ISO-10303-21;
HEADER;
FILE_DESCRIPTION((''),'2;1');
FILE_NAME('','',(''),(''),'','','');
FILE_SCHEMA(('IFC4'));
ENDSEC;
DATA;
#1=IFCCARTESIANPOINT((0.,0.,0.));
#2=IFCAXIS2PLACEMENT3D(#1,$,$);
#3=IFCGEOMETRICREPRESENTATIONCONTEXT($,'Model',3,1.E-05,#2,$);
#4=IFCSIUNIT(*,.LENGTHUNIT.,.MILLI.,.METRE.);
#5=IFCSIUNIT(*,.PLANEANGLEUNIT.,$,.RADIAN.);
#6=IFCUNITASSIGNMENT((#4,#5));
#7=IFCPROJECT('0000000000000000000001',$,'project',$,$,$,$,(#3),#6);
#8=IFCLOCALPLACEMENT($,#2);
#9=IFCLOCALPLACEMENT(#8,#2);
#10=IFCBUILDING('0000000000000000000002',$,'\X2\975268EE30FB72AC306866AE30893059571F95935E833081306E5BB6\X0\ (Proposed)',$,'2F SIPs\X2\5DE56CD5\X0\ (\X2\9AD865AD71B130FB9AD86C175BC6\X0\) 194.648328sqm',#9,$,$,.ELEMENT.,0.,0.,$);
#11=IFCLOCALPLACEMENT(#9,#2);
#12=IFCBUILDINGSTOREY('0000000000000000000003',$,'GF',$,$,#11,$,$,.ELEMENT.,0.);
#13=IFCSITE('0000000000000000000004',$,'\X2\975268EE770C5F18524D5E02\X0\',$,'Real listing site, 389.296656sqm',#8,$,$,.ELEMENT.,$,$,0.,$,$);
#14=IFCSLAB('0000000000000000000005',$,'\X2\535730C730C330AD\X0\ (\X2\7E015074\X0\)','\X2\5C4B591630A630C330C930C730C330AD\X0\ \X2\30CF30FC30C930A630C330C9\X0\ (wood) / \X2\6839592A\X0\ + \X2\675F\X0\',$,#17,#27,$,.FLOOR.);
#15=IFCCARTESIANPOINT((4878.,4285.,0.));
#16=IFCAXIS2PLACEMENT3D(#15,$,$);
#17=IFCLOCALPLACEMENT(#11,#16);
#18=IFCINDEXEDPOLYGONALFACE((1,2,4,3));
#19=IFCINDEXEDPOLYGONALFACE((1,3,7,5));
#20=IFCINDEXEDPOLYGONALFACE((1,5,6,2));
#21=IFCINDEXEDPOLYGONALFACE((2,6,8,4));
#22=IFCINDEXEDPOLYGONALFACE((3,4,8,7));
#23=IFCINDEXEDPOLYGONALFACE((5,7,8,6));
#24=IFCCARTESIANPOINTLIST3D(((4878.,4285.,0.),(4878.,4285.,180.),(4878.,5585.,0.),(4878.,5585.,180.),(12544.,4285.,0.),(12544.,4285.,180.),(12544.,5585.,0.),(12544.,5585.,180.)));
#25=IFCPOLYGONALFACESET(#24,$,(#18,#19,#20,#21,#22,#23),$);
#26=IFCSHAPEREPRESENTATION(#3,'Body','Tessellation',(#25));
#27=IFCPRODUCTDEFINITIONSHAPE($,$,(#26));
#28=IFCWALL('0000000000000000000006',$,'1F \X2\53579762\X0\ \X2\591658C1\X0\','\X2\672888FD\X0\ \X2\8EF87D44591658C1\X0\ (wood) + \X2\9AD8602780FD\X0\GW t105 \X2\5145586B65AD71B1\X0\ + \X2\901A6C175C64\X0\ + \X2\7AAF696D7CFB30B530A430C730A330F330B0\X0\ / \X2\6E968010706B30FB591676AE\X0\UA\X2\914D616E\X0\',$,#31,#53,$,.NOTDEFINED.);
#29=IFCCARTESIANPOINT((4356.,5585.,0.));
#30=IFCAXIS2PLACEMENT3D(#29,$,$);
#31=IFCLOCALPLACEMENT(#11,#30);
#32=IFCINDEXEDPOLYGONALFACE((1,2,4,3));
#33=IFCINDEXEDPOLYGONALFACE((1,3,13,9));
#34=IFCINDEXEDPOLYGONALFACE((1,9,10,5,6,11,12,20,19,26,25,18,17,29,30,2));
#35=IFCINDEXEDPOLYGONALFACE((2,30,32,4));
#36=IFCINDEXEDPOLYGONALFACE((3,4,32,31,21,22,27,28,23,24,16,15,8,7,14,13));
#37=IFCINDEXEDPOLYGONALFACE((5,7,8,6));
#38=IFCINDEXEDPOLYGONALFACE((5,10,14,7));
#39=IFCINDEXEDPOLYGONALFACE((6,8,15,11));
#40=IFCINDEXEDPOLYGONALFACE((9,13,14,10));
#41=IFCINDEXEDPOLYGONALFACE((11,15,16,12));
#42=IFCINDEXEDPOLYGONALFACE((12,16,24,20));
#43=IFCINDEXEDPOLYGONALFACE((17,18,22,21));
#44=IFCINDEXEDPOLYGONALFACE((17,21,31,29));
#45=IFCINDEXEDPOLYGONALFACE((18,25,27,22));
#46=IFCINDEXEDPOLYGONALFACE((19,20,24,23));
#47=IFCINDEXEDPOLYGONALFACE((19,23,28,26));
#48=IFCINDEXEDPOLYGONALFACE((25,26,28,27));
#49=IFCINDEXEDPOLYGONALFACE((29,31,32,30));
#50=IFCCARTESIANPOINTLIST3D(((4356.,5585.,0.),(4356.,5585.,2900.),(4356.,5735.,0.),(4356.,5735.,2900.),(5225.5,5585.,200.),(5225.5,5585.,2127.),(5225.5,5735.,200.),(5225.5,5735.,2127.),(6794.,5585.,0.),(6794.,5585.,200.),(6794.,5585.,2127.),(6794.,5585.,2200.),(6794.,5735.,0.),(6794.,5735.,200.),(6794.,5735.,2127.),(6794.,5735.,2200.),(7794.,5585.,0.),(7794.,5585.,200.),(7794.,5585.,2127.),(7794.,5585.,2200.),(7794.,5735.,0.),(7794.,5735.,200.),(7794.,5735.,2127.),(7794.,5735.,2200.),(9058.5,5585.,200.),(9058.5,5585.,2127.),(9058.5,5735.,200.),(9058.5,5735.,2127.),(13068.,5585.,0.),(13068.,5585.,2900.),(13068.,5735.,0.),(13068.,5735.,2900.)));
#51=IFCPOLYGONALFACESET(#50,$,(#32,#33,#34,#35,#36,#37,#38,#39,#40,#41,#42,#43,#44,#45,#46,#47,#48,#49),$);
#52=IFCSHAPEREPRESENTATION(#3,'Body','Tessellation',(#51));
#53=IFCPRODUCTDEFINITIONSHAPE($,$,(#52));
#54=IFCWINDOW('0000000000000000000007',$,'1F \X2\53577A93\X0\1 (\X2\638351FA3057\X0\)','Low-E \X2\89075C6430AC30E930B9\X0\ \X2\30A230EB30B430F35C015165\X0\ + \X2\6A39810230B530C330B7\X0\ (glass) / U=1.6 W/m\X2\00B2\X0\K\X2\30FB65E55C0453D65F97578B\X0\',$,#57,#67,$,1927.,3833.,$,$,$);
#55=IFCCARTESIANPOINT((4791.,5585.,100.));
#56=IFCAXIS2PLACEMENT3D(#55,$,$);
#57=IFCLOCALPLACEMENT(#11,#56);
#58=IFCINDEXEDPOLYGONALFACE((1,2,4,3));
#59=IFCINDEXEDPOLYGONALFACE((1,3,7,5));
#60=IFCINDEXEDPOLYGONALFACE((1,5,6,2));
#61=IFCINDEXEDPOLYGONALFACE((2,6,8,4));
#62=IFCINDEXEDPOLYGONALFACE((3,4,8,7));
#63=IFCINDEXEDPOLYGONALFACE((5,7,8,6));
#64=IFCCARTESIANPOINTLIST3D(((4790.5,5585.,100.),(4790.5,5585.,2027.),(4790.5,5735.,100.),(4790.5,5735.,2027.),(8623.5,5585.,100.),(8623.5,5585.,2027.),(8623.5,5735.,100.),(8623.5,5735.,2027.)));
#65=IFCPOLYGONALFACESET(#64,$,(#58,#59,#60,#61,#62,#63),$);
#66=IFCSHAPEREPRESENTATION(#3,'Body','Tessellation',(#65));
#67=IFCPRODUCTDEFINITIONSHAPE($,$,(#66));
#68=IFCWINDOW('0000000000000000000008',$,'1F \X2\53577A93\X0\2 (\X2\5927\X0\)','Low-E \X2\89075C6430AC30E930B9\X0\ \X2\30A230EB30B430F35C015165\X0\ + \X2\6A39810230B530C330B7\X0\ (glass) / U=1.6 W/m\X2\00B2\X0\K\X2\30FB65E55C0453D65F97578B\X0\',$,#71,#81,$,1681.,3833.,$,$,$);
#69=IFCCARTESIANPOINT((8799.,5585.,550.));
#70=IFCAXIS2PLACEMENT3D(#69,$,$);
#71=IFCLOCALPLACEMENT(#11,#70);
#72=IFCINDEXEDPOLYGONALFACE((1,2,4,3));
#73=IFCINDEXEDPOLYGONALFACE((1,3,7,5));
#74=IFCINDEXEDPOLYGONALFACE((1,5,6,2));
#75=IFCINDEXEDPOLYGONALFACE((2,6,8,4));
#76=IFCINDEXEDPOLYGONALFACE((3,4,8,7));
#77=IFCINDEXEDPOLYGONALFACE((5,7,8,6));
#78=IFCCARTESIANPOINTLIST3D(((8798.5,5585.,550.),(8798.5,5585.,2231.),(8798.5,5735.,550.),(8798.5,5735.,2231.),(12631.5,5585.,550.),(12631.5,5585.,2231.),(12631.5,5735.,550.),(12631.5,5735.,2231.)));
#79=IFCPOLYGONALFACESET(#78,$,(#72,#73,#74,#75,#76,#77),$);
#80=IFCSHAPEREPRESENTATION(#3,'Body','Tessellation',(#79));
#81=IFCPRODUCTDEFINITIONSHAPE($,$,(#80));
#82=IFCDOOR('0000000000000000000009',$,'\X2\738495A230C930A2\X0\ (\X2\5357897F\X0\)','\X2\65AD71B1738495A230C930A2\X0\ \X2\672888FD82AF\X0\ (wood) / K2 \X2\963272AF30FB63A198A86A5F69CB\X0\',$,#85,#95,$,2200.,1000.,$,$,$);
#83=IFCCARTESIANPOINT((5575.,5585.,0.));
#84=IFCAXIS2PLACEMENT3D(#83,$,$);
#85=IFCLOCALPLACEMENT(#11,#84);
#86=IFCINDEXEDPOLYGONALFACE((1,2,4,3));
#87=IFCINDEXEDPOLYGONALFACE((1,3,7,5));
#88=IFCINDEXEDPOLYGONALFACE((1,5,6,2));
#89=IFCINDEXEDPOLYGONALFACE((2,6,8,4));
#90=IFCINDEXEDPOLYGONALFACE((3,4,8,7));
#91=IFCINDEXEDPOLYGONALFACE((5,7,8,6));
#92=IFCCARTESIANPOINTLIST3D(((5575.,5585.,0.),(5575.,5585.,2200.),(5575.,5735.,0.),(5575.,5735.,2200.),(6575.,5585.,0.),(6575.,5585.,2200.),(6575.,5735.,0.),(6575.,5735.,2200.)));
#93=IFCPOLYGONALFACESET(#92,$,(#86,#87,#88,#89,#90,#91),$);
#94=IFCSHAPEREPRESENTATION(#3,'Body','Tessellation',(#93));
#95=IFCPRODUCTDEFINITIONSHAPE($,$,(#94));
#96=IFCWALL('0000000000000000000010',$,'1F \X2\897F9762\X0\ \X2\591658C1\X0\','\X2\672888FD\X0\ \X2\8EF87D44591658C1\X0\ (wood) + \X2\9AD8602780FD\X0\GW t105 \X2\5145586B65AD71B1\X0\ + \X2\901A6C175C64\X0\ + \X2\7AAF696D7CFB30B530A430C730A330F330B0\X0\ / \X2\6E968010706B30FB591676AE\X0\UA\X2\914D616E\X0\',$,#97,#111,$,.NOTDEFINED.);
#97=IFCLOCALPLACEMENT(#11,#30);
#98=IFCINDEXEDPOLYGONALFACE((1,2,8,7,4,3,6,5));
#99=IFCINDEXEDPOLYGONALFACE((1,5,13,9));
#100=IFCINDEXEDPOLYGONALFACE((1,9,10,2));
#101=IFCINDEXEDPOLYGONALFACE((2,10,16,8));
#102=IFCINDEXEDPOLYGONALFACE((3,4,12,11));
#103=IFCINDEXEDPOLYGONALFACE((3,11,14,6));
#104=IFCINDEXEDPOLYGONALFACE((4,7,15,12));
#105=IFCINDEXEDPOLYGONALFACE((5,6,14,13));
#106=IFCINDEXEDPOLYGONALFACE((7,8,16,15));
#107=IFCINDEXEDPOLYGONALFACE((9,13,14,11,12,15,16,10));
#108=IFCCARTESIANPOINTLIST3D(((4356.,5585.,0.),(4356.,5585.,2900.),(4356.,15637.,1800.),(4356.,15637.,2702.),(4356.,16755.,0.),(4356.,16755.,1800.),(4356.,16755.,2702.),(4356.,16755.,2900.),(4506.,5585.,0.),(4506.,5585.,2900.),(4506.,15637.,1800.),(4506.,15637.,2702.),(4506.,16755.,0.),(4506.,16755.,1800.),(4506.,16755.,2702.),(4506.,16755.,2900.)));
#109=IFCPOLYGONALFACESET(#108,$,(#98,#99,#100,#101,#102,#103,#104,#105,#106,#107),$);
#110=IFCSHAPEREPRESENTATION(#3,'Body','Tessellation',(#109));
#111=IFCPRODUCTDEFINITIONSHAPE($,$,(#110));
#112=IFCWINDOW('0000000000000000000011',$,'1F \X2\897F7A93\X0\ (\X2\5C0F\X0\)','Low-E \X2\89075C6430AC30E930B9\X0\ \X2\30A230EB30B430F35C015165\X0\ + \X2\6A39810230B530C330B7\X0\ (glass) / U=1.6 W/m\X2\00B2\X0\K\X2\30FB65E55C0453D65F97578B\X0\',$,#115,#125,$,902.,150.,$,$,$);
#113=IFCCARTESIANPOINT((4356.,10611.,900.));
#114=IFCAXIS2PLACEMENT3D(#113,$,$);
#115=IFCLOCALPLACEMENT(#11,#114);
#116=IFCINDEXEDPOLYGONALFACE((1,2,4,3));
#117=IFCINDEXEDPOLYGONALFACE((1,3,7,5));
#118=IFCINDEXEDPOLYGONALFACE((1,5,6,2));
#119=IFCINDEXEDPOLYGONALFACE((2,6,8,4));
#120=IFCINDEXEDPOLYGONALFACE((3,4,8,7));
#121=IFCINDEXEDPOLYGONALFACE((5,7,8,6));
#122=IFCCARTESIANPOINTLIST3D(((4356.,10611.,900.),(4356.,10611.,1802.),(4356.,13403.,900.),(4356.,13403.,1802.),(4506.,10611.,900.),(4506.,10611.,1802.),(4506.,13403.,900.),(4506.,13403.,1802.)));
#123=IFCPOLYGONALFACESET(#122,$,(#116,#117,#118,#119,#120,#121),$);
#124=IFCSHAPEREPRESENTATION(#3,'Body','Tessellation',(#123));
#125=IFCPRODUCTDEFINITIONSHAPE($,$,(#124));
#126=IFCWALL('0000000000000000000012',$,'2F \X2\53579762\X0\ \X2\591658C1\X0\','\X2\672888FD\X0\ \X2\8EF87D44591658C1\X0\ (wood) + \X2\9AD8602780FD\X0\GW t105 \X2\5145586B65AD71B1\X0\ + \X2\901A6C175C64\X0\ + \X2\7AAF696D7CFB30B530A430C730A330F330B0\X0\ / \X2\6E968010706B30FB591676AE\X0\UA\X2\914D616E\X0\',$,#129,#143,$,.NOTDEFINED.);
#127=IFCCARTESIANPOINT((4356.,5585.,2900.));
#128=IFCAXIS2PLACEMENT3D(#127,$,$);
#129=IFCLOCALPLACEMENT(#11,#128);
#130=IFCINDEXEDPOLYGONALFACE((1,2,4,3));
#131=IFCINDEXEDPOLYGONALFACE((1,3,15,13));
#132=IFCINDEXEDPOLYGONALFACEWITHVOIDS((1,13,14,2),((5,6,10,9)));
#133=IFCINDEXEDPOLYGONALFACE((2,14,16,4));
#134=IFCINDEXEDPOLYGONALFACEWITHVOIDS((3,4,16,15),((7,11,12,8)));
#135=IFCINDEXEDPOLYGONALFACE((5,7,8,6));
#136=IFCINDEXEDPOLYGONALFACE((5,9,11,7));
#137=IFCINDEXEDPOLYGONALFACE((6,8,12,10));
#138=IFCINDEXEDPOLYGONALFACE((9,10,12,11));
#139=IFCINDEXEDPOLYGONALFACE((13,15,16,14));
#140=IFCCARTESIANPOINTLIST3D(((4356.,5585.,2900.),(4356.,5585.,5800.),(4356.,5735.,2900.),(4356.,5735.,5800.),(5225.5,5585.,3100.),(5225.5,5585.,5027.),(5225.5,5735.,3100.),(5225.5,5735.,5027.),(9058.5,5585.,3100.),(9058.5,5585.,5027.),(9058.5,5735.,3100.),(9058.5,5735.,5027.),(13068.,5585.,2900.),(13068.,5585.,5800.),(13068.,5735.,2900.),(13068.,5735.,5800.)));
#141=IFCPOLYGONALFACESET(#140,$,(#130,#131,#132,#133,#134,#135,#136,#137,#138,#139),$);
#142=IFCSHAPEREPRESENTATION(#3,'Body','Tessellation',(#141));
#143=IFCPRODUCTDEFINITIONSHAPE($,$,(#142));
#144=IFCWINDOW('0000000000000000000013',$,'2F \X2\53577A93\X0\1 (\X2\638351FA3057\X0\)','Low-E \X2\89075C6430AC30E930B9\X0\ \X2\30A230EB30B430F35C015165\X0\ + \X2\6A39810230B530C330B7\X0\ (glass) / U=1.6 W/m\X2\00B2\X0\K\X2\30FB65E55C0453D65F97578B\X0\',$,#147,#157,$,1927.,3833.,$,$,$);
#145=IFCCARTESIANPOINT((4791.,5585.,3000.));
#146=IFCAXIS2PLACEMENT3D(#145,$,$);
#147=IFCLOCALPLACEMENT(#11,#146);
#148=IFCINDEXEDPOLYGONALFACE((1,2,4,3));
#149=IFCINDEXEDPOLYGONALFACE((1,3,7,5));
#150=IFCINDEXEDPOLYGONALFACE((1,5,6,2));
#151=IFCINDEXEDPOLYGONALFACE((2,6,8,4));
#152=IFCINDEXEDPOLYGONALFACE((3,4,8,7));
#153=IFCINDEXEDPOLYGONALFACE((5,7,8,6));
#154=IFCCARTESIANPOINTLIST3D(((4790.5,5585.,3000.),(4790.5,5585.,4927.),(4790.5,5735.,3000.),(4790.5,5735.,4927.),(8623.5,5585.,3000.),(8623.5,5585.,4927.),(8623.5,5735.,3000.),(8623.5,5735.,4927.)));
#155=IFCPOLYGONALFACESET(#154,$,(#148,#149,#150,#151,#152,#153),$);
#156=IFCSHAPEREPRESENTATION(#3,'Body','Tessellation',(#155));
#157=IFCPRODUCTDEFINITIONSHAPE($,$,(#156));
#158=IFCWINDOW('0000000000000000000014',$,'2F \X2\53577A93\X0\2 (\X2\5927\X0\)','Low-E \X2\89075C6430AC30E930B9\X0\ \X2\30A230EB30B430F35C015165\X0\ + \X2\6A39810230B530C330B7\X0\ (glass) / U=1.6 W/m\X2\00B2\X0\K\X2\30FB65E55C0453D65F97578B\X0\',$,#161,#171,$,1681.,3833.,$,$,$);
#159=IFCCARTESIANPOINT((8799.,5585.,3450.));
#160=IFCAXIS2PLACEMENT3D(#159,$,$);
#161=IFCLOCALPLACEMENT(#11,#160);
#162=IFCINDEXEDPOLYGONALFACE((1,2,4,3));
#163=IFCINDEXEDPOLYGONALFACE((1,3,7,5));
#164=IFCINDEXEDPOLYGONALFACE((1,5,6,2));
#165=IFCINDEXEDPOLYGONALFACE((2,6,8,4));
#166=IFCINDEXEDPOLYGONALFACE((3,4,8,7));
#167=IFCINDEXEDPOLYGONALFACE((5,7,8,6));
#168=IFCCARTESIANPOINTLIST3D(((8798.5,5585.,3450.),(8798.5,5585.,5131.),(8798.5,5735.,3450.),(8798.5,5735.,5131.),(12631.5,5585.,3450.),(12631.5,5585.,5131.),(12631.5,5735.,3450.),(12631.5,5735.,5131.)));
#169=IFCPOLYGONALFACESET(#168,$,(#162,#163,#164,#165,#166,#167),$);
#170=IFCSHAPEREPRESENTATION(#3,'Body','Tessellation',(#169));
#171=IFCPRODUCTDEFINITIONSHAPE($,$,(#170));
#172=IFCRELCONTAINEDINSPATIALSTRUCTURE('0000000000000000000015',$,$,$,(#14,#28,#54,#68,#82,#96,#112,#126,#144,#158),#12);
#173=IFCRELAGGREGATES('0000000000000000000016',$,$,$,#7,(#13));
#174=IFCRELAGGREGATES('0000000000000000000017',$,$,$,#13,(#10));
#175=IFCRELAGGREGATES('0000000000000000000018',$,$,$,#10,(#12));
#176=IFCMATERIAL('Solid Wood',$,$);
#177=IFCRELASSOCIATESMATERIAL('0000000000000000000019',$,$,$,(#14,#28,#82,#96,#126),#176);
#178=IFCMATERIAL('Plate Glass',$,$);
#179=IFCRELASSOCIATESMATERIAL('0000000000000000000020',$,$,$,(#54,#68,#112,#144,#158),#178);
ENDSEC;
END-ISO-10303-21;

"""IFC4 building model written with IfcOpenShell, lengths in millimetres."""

from ifc_helpers import new_model, si_unit, frame, frame_2d, origin, place, context, project, spatial, rectangle, extrude, material, element, fill, save


model = new_model("IFC4")

# Units and contexts
model_context = context("Model", 3, precision=1e-05, world=origin())
ifc_project = project(units=[si_unit("LENGTHUNIT", "METRE", prefix="MILLI"), si_unit("PLANEANGLEUNIT", "RADIAN")], contexts=[model_context])

# Site, building, storey
site_placement = place(None, origin())
site = spatial("IfcSite", under=ifc_project, at=site_placement, Name="青森県弘前市", ObjectType="Real listing site, 389.296656sqm", CompositionType="ELEMENT", RefElevation=0.0)
building_placement = place(site_placement, origin())
building = spatial("IfcBuilding", under=site, at=building_placement, Name="青森・犬と暮らす土間広めの家 (Proposed)", ObjectType="2F SIPs工法 (高断熱・高気密) 194.648328sqm", CompositionType="ELEMENT", ElevationOfRefHeight=0.0, ElevationOfTerrain=0.0)
storey_placement = place(building_placement, origin())
storey = spatial("IfcBuildingStorey", under=building, at=storey_placement, Name="GF", CompositionType="ELEMENT", Elevation=0.0)

# Slab
ifc_material_1 = material(Name="Solid Wood")
slab_1_placement = place(storey_placement, frame((4878.0, 4285.0, 0.0)))
element("IfcSlab", 1, at=slab_1_placement, inside=storey, material=ifc_material_1, Name="南デッキ (縁側)", Description="屋外ウッドデッキ ハードウッド (wood) / 根太 + 束", PredefinedType="FLOOR", context=model_context, shape_type="SweptSolid", body=[
    extrude(rectangle(XDim=7666.0, YDim=1300.0, at=frame_2d((3833.0, 650.0))), frame((4878.0, 4285.0, 0.0)), (0.0, 0.0, 1.0), 180.0),
])

# Wall, openings, windows, door
wall_1_placement = place(storey_placement, frame((4356.0, 5585.0, 0.0)))
wall_1 = element("IfcWall", 2, at=wall_1_placement, inside=storey, material=ifc_material_1, Name="1F 南面 外壁", Description="木製 軸組外壁 (wood) + 高性能GW t105 充填断熱 + 通気層 + 窯業系サイディング / 準耐火・外皮UA配慮", PredefinedType="NOTDEFINED", context=model_context, shape_type="SweptSolid", body=[
    extrude(rectangle(XDim=8712.0, YDim=150.0, at=frame_2d((4356.0, 75.0))), frame((4356.0, 5585.0, 0.0)), (0.0, 0.0, 1.0), 2900.0),
])
opening_1_placement = place(storey_placement, frame((4791.0, 5585.0, 100.0)))
opening_1 = element("IfcOpeningElement", 3, at=opening_1_placement, cuts=wall_1, PredefinedType="NOTDEFINED", context=model_context, shape_type="SweptSolid", body=[
    extrude(rectangle(XDim=3833.0, YDim=150.0, at=frame_2d((1916.0, 75.0))), frame((4791.0, 5585.0, 100.0)), (0.0, 0.0, 1.0), 1927.0),
])
opening_2_placement = place(storey_placement, frame((8799.0, 5585.0, 550.0)))
opening_2 = element("IfcOpeningElement", 4, at=opening_2_placement, cuts=wall_1, PredefinedType="NOTDEFINED", context=model_context, shape_type="SweptSolid", body=[
    extrude(rectangle(XDim=3833.0, YDim=150.0, at=frame_2d((1916.0, 75.0))), frame((8799.0, 5585.0, 550.0)), (0.0, 0.0, 1.0), 1681.0),
])
opening_3_placement = place(storey_placement, frame((5575.0, 5585.0, 0.0)))
opening_3 = element("IfcOpeningElement", 5, at=opening_3_placement, cuts=wall_1, PredefinedType="NOTDEFINED", context=model_context, shape_type="SweptSolid", body=[
    extrude(rectangle(XDim=1000.0, YDim=150.0, at=frame_2d((500.0, 75.0))), frame((5575.0, 5585.0, 0.0)), (0.0, 0.0, 1.0), 2200.0),
])
ifc_material_2 = material(Name="Plate Glass")
window_1_placement = place(storey_placement, frame((4791.0, 5585.0, 100.0)))
window_1 = element("IfcWindow", 6, at=window_1_placement, inside=storey, material=ifc_material_2, Name="1F 南窓1 (掃出し)", Description="Low-E 複層ガラス アルゴン封入 + 樹脂サッシ (glass) / U=1.6 W/m²K・日射取得型", OverallHeight=1927.0, OverallWidth=3833.0, context=model_context, shape_type="SweptSolid", body=[
    extrude(rectangle(XDim=3833.0, YDim=150.0, at=frame_2d((1916.0, 75.0))), frame((4791.0, 5585.0, 100.0)), (0.0, 0.0, 1.0), 1927.0),
])
fill(opening_1, window_1)
window_2_placement = place(storey_placement, frame((8799.0, 5585.0, 550.0)))
window_2 = element("IfcWindow", 7, at=window_2_placement, inside=storey, material=ifc_material_2, Name="1F 南窓2 (大)", Description="Low-E 複層ガラス アルゴン封入 + 樹脂サッシ (glass) / U=1.6 W/m²K・日射取得型", OverallHeight=1681.0, OverallWidth=3833.0, context=model_context, shape_type="SweptSolid", body=[
    extrude(rectangle(XDim=3833.0, YDim=150.0, at=frame_2d((1916.0, 75.0))), frame((8799.0, 5585.0, 550.0)), (0.0, 0.0, 1.0), 1681.0),
])
fill(opening_2, window_2)
door_placement = place(storey_placement, frame((5575.0, 5585.0, 0.0)))
door = element("IfcDoor", 8, at=door_placement, inside=storey, material=ifc_material_1, Name="玄関ドア (南西)", Description="断熱玄関ドア 木製芯 (wood) / K2 防犯・採風機構", OverallHeight=2200.0, OverallWidth=1000.0, context=model_context, shape_type="SweptSolid", body=[
    extrude(rectangle(XDim=1000.0, YDim=150.0, at=frame_2d((500.0, 75.0))), frame((5575.0, 5585.0, 0.0)), (0.0, 0.0, 1.0), 2200.0),
])
fill(opening_3, door)

# Wall, opening, window
wall_2_placement = place(storey_placement, frame((4356.0, 5585.0, 0.0)))
wall_2 = element("IfcWall", 9, at=wall_2_placement, inside=storey, material=ifc_material_1, Name="1F 西面 外壁", Description="木製 軸組外壁 (wood) + 高性能GW t105 充填断熱 + 通気層 + 窯業系サイディング / 準耐火・外皮UA配慮", PredefinedType="NOTDEFINED", context=model_context, shape_type="SweptSolid", body=[
    extrude(rectangle(XDim=150.0, YDim=11170.0, at=frame_2d((75.0, 5585.0))), frame((4356.0, 5585.0, 0.0)), (0.0, 0.0, 1.0), 2900.0),
])
opening_4_placement = place(storey_placement, frame((4356.0, 10611.0, 900.0)))
opening_4 = element("IfcOpeningElement", 10, at=opening_4_placement, cuts=wall_2, PredefinedType="NOTDEFINED", context=model_context, shape_type="SweptSolid", body=[
    extrude(rectangle(XDim=150.0, YDim=2792.0, at=frame_2d((75.0, 1396.0))), frame((4356.0, 10611.0, 900.0)), (0.0, 0.0, 1.0), 902.0),
])
window_3_placement = place(storey_placement, frame((4356.0, 10611.0, 900.0)))
window_3 = element("IfcWindow", 11, at=window_3_placement, inside=storey, material=ifc_material_2, Name="1F 西窓 (小)", Description="Low-E 複層ガラス アルゴン封入 + 樹脂サッシ (glass) / U=1.6 W/m²K・日射取得型", OverallHeight=902.0, OverallWidth=150.0, context=model_context, shape_type="SweptSolid", body=[
    extrude(rectangle(XDim=150.0, YDim=2792.0, at=frame_2d((75.0, 1396.0))), frame((4356.0, 10611.0, 900.0)), (0.0, 0.0, 1.0), 902.0),
])
fill(opening_4, window_3)

# Wall, openings, windows
wall_3_placement = place(storey_placement, frame((4356.0, 5585.0, 2900.0)))
wall_3 = element("IfcWall", 12, at=wall_3_placement, inside=storey, material=ifc_material_1, Name="2F 南面 外壁", Description="木製 軸組外壁 (wood) + 高性能GW t105 充填断熱 + 通気層 + 窯業系サイディング / 準耐火・外皮UA配慮", PredefinedType="NOTDEFINED", context=model_context, shape_type="SweptSolid", body=[
    extrude(rectangle(XDim=8712.0, YDim=150.0, at=frame_2d((4356.0, 75.0))), frame((4356.0, 5585.0, 2900.0)), (0.0, 0.0, 1.0), 2900.0),
])
opening_5_placement = place(storey_placement, frame((4791.0, 5585.0, 3000.0)))
opening_5 = element("IfcOpeningElement", 13, at=opening_5_placement, cuts=wall_3, PredefinedType="NOTDEFINED", context=model_context, shape_type="SweptSolid", body=[
    extrude(rectangle(XDim=3833.0, YDim=150.0, at=frame_2d((1916.0, 75.0))), frame((4791.0, 5585.0, 3000.0)), (0.0, 0.0, 1.0), 1927.0),
])
opening_6_placement = place(storey_placement, frame((8799.0, 5585.0, 3450.0)))
opening_6 = element("IfcOpeningElement", 14, at=opening_6_placement, cuts=wall_3, PredefinedType="NOTDEFINED", context=model_context, shape_type="SweptSolid", body=[
    extrude(rectangle(XDim=3833.0, YDim=150.0, at=frame_2d((1916.0, 75.0))), frame((8799.0, 5585.0, 3450.0)), (0.0, 0.0, 1.0), 1681.0),
])
window_4_placement = place(storey_placement, frame((4791.0, 5585.0, 3000.0)))
window_4 = element("IfcWindow", 15, at=window_4_placement, inside=storey, material=ifc_material_2, Name="2F 南窓1 (掃出し)", Description="Low-E 複層ガラス アルゴン封入 + 樹脂サッシ (glass) / U=1.6 W/m²K・日射取得型", OverallHeight=1927.0, OverallWidth=3833.0, context=model_context, shape_type="SweptSolid", body=[
    extrude(rectangle(XDim=3833.0, YDim=150.0, at=frame_2d((1916.0, 75.0))), frame((4791.0, 5585.0, 3000.0)), (0.0, 0.0, 1.0), 1927.0),
])
fill(opening_5, window_4)
window_5_placement = place(storey_placement, frame((8799.0, 5585.0, 3450.0)))
window_5 = element("IfcWindow", 16, at=window_5_placement, inside=storey, material=ifc_material_2, Name="2F 南窓2 (大)", Description="Low-E 複層ガラス アルゴン封入 + 樹脂サッシ (glass) / U=1.6 W/m²K・日射取得型", OverallHeight=1681.0, OverallWidth=3833.0, context=model_context, shape_type="SweptSolid", body=[
    extrude(rectangle(XDim=3833.0, YDim=150.0, at=frame_2d((1916.0, 75.0))), frame((8799.0, 5585.0, 3450.0)), (0.0, 0.0, 1.0), 1681.0),
])
fill(opening_6, window_5)

save(model, "model.ifc")
